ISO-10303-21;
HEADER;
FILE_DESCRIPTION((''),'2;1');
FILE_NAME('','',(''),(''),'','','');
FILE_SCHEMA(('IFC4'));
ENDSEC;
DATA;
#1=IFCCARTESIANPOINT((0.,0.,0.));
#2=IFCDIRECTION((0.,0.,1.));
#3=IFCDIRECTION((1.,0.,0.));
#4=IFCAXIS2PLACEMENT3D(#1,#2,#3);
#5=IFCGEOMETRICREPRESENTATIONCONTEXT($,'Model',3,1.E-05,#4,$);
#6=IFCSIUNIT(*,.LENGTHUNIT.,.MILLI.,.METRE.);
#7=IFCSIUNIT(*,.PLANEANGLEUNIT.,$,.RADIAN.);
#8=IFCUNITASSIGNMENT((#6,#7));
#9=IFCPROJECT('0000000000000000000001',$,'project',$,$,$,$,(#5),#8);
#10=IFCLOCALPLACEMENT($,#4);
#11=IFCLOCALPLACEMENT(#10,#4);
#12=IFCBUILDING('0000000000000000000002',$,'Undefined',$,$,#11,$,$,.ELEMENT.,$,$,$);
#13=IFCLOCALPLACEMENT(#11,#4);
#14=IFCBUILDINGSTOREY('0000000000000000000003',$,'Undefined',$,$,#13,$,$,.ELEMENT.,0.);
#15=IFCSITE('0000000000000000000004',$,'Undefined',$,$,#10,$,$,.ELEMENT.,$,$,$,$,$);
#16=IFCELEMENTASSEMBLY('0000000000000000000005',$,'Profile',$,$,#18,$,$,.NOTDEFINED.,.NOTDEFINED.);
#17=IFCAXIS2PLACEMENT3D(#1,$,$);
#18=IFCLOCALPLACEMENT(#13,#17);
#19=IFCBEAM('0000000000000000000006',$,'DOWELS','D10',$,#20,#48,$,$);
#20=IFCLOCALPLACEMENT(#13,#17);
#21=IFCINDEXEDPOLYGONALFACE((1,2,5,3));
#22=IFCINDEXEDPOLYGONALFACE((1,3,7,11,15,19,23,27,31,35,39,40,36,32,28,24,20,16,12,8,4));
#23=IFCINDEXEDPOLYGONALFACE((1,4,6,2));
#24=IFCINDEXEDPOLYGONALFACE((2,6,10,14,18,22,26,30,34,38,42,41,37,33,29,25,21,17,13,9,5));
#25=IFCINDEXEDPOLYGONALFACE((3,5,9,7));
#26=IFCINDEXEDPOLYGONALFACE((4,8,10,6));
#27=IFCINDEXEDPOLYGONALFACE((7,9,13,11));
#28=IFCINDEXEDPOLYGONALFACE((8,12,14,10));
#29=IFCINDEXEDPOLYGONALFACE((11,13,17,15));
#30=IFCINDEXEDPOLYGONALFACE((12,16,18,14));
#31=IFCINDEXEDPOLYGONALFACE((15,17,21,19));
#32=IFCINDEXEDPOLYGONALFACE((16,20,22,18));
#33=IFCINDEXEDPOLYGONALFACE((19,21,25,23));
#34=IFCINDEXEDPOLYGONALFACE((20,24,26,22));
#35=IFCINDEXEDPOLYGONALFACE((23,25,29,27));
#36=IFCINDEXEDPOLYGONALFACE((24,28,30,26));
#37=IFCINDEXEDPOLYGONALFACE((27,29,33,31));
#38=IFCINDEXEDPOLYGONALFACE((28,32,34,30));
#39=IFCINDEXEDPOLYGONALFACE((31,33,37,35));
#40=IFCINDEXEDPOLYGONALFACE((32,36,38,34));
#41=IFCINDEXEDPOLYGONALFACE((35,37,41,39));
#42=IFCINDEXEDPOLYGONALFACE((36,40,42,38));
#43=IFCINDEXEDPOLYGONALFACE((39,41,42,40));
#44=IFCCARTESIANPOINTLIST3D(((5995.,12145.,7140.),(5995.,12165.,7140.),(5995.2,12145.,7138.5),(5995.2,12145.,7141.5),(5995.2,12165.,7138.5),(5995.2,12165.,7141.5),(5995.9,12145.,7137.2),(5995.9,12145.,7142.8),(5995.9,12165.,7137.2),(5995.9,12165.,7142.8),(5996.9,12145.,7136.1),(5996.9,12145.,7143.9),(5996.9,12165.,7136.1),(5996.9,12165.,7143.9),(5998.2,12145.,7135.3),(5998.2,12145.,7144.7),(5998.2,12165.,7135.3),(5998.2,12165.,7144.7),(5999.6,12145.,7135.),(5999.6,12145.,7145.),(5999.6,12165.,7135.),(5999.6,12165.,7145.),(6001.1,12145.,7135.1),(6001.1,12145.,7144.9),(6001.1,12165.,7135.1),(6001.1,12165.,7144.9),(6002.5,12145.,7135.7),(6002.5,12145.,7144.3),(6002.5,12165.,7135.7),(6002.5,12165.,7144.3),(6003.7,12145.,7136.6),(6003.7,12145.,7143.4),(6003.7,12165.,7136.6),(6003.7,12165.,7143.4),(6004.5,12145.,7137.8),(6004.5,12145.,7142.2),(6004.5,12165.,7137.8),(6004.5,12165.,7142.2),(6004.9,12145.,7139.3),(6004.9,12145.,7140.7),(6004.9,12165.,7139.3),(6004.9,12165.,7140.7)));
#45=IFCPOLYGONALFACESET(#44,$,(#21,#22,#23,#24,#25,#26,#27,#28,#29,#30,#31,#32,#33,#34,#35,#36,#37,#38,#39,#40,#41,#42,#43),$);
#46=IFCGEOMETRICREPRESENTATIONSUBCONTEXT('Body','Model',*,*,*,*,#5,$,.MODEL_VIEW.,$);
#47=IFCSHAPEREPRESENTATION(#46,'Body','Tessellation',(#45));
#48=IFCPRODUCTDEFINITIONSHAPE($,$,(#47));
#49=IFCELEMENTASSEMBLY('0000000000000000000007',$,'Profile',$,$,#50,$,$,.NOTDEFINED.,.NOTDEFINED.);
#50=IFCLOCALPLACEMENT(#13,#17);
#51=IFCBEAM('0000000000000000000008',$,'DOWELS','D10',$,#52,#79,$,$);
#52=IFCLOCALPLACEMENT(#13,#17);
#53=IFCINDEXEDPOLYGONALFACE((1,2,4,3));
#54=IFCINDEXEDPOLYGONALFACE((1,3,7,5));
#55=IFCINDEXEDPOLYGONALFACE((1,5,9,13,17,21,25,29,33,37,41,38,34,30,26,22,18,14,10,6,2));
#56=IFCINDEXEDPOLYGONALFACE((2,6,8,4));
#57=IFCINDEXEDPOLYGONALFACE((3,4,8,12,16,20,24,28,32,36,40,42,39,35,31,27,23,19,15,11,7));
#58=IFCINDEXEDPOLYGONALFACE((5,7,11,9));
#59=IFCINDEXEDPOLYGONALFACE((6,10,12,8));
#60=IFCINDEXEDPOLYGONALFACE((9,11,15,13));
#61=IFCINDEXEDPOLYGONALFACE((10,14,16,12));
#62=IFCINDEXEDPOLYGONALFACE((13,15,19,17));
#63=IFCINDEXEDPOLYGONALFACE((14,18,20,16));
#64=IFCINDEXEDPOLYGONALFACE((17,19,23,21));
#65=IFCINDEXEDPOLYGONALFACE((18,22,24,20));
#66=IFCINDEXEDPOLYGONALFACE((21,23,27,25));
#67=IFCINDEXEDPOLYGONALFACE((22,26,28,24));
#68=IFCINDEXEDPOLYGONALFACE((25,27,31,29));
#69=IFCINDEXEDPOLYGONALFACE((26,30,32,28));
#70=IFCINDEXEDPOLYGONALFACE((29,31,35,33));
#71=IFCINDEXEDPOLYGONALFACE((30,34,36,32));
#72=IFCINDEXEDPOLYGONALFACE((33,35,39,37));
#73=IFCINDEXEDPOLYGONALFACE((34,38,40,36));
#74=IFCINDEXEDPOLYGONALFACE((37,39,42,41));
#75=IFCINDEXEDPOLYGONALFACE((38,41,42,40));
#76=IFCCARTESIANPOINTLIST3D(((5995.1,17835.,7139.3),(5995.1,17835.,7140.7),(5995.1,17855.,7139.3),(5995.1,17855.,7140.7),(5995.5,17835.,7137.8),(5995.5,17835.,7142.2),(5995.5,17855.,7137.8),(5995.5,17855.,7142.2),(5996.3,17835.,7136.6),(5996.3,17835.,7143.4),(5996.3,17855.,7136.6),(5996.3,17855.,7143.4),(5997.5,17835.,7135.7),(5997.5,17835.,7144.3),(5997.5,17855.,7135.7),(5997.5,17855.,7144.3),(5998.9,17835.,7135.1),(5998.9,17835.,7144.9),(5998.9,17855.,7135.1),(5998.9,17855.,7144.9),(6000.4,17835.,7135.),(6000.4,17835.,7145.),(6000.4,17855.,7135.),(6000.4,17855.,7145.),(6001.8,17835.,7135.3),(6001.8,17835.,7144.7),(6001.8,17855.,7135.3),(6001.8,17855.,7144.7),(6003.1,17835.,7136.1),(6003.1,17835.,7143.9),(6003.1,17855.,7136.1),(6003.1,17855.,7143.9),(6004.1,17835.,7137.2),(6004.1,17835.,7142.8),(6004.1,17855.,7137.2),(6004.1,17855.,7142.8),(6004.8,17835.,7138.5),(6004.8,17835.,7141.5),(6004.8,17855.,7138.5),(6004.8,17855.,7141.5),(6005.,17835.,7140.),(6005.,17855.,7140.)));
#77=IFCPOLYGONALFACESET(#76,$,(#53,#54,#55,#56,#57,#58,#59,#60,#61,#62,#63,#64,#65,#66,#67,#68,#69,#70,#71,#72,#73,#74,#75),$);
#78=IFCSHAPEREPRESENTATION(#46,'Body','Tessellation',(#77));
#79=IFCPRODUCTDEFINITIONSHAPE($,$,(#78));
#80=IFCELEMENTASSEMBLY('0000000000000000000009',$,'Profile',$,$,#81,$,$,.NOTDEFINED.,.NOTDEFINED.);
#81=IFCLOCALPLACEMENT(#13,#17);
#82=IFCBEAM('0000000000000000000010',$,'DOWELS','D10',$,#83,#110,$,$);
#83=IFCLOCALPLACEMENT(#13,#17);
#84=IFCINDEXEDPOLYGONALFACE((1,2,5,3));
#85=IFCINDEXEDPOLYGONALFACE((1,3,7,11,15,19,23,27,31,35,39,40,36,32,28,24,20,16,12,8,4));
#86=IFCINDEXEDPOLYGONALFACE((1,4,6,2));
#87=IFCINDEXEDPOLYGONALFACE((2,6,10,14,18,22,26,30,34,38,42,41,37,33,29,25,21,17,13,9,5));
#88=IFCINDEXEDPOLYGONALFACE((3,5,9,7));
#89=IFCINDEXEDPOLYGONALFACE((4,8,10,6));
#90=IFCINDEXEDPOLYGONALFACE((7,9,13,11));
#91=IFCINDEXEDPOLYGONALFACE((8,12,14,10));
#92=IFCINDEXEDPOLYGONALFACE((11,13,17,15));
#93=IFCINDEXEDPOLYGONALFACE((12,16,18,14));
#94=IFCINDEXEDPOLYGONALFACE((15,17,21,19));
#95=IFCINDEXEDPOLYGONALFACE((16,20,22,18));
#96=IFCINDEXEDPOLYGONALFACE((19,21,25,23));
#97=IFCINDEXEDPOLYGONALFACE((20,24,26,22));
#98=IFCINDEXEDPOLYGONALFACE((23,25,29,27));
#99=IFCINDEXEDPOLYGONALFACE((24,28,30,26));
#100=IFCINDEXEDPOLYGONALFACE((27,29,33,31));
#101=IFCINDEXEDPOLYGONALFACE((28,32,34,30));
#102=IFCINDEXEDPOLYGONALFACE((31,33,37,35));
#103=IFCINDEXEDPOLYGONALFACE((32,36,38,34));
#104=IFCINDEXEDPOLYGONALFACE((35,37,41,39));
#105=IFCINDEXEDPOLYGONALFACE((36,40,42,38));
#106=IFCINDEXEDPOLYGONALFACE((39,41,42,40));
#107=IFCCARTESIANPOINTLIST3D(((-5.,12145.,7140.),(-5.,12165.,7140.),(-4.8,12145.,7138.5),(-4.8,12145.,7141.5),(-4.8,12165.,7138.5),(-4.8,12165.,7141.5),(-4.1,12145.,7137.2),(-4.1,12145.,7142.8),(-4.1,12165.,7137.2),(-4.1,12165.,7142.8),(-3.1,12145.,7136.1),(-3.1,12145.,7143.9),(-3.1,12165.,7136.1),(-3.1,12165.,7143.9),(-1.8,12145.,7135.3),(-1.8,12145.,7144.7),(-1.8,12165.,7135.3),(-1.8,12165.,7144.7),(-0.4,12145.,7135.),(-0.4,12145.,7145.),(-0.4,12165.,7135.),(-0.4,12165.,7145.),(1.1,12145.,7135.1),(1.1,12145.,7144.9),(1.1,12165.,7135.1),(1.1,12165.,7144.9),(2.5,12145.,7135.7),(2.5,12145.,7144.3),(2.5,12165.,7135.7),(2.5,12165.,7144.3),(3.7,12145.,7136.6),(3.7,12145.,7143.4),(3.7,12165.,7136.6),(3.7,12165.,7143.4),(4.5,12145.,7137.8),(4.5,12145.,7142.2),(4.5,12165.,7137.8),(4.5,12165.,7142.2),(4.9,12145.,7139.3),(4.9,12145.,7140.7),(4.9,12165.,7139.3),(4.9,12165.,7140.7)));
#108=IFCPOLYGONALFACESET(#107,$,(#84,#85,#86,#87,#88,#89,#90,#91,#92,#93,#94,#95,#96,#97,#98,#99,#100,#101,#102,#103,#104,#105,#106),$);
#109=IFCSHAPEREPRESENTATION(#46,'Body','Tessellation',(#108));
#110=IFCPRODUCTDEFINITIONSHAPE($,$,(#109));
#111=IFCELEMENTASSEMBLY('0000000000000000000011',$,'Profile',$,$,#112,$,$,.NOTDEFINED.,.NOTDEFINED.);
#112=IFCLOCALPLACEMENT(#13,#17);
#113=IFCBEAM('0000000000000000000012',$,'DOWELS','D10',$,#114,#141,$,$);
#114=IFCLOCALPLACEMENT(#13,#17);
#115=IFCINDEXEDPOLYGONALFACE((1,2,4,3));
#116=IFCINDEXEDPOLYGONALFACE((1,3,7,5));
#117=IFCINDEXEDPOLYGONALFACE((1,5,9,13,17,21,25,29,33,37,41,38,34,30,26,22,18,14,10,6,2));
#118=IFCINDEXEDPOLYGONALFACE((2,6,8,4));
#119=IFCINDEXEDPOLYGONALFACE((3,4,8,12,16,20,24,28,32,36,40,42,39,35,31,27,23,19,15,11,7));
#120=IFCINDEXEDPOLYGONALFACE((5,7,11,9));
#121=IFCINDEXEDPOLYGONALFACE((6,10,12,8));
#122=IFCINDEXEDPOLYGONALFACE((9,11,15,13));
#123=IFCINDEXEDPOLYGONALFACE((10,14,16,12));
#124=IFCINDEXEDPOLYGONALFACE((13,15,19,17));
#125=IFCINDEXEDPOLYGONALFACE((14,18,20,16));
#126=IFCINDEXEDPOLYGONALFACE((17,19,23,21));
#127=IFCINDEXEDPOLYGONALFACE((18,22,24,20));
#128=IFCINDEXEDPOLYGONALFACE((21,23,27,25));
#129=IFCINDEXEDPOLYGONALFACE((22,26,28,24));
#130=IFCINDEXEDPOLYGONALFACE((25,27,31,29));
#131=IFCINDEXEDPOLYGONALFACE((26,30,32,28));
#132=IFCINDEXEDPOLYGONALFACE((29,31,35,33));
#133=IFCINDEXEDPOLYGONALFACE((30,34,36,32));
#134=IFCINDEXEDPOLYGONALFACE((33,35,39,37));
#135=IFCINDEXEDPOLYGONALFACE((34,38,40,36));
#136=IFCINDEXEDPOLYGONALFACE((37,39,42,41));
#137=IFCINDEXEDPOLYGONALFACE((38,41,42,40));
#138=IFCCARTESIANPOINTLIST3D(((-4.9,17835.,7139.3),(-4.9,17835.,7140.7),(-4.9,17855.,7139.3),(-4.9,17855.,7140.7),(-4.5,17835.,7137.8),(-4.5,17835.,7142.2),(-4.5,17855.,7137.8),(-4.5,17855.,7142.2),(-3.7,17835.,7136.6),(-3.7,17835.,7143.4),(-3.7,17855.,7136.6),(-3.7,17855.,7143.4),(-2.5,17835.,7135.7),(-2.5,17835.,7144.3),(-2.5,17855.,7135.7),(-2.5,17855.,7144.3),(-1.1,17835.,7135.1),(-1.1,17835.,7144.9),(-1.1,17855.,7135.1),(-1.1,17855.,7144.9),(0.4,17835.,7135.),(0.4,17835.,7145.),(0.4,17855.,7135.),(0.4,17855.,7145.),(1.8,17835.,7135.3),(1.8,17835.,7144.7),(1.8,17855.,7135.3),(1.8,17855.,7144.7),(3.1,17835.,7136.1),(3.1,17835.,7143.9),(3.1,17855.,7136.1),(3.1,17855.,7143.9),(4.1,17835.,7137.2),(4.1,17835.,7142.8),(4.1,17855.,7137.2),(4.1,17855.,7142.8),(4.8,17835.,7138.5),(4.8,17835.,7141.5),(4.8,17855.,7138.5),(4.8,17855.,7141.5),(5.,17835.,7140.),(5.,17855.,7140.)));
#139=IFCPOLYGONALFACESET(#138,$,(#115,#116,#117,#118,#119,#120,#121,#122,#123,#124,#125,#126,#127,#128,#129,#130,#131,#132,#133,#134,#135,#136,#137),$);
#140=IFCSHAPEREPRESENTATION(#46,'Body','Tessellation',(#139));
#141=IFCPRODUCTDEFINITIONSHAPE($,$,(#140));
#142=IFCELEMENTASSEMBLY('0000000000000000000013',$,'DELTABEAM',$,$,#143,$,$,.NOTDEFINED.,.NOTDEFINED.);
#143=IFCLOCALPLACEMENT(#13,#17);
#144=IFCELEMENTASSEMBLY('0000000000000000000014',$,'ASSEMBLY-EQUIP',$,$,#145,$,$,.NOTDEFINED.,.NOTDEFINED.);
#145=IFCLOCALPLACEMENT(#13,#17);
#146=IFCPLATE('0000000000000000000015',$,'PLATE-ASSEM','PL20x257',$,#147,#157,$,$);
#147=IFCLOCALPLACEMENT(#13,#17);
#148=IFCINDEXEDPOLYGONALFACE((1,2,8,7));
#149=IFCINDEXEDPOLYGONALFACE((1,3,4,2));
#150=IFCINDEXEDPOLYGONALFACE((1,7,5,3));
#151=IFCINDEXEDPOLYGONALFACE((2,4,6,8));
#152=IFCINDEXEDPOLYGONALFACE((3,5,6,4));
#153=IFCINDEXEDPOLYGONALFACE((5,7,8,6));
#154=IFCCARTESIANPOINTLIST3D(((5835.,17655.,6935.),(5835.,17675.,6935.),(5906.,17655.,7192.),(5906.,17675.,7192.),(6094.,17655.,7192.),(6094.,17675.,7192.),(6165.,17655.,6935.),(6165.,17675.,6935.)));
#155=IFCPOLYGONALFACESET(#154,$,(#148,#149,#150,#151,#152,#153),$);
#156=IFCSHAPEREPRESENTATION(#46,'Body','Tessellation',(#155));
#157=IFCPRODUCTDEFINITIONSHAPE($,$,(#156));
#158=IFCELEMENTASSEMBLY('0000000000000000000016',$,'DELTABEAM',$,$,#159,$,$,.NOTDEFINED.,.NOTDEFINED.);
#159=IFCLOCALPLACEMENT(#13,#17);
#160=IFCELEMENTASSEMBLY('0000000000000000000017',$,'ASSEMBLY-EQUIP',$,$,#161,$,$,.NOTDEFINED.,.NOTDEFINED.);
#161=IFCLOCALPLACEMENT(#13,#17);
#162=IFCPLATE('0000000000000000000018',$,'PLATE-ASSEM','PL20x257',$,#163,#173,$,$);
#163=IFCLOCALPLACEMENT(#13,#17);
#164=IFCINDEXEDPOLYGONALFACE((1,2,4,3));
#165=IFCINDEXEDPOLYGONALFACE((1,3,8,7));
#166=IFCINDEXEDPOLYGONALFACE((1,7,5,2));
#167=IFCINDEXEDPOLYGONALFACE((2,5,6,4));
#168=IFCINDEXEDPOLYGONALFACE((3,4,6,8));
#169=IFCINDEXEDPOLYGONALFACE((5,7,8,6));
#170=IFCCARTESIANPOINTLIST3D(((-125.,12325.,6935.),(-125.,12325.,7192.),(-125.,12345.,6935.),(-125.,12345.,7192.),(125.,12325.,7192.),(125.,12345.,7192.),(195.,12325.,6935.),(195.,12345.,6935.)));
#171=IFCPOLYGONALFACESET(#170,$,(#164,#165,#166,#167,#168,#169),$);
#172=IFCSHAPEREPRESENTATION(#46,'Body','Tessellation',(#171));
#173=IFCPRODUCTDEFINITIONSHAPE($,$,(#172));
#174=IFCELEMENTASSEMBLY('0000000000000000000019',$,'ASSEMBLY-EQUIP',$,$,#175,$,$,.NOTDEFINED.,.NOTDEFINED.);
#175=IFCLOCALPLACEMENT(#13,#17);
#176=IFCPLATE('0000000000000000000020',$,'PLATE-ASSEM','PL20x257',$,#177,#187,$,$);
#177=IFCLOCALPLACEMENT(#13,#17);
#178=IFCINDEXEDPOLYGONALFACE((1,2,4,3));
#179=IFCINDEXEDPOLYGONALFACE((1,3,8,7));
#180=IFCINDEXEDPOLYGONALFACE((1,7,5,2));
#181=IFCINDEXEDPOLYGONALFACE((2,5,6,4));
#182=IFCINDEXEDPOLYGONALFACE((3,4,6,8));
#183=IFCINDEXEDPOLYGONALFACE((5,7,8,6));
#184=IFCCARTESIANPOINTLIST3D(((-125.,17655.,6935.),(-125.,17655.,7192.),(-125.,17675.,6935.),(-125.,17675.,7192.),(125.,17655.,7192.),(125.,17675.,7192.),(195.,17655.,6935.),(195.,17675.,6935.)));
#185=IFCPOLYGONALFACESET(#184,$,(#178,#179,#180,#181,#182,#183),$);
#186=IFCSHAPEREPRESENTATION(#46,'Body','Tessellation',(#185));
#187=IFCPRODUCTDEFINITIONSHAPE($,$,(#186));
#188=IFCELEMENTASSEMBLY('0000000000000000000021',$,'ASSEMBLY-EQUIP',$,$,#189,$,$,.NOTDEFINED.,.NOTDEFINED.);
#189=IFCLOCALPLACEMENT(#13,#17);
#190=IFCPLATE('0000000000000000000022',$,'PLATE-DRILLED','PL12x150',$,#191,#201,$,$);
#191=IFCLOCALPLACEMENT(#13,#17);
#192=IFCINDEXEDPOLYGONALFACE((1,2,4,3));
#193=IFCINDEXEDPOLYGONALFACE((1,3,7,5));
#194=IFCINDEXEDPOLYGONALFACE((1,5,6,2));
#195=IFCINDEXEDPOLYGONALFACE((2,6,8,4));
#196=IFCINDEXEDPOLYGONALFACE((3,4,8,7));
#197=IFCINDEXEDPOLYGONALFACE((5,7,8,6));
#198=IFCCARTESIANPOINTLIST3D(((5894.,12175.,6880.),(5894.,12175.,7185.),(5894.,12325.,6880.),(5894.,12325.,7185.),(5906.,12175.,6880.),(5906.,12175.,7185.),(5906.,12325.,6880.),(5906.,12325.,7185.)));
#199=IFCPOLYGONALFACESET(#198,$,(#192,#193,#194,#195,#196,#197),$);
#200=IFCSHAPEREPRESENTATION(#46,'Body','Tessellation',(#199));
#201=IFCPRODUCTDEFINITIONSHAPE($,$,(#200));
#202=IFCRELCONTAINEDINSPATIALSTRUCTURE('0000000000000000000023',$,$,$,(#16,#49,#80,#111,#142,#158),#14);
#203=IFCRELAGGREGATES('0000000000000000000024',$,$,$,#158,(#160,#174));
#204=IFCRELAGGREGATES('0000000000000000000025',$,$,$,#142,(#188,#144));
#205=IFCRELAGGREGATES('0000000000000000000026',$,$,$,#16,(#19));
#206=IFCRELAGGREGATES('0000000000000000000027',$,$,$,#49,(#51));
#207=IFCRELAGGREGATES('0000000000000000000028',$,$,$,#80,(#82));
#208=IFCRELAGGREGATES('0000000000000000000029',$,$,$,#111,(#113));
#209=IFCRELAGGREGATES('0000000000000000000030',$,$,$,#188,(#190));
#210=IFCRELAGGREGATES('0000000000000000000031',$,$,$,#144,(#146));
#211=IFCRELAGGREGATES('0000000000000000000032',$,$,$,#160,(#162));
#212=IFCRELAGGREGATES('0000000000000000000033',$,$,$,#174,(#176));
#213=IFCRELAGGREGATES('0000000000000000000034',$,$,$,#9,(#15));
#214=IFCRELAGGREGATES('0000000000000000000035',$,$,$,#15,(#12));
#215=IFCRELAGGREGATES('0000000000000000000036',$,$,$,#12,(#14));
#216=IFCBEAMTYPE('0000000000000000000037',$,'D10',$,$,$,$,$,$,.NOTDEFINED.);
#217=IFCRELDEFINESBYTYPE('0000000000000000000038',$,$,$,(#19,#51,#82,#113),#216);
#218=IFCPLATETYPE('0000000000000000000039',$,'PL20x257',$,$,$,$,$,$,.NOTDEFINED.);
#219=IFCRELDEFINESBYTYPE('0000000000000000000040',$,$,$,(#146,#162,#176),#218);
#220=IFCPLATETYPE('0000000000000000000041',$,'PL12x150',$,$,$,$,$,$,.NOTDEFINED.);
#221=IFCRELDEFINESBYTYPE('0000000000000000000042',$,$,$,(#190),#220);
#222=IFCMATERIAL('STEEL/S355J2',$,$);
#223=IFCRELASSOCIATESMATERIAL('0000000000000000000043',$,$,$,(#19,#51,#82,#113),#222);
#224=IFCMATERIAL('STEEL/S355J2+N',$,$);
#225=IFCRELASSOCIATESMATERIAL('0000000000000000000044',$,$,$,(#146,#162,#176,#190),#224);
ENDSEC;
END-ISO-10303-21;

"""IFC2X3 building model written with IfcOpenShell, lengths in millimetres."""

from ifc_helpers import new_model, si_unit, frame, origin_with_axes, origin_2d_with_axis, place, context, subcontext, project, spatial, polyline, circle, outline, extrude, material, type_object, element, aggregate, save


model = new_model("IFC2X3")

# Units and contexts
model_context = context("Model", 3, precision=1e-05, world=origin_with_axes())
body_context = subcontext(model_context, "Body", "Model", "MODEL_VIEW")
ifc_project = project(units=[si_unit("LENGTHUNIT", "METRE", prefix="MILLI"), si_unit("PLANEANGLEUNIT", "RADIAN")], contexts=[model_context])

# Site, building, storey
site_placement = place(None, origin_with_axes())
site = spatial("IfcSite", under=ifc_project, at=site_placement, Name="Undefined", CompositionType="ELEMENT")
building_placement = place(site_placement, origin_with_axes())
building = spatial("IfcBuilding", under=site, at=building_placement, Name="Undefined", CompositionType="ELEMENT")
storey_placement = place(building_placement, origin_with_axes())
storey = spatial("IfcBuildingStorey", under=building, at=storey_placement, Name="Undefined", CompositionType="ELEMENT", Elevation=0.0)

# Element assemblies, beams
assembly_1_placement = place(storey_placement, origin_with_axes())
assembly_1 = element("IfcElementAssembly", 1, at=assembly_1_placement, inside=storey, Name="Profile", AssemblyPlace="NOTDEFINED", PredefinedType="NOTDEFINED")
ifc_material_1 = material(Name="STEEL/S355J2")
beam_type_1 = type_object("IfcBeamType", Name="D10", PredefinedType="NOTDEFINED")
beam_1_placement = place(assembly_1_placement, frame((6000.0, 12165.0, 7140.0), z_axis=(0.0, 0.0, 1.0), x_axis=(0.0, -1.0, 0.0)))
beam_1 = element("IfcBeam", 2, at=beam_1_placement, type_object=beam_type_1, material=ifc_material_1, Name="DOWELS", Description="D10", context=body_context, shape_type="SweptSolid", body=[
    extrude(circle(Radius=5.0, at=origin_2d_with_axis()), frame((20.0, 0.0, 0.0), z_axis=(-1.0, 0.0, 0.0), x_axis=(0.0, -1.0, 0.0)), (0.0, 0.0, 1.0), 20.0),
])
assembly_2_placement = place(storey_placement, origin_with_axes())
assembly_2 = element("IfcElementAssembly", 3, at=assembly_2_placement, inside=storey, Name="Profile", AssemblyPlace="NOTDEFINED", PredefinedType="NOTDEFINED")
beam_2_placement = place(assembly_2_placement, frame((6000.0, 17835.0, 7140.0), z_axis=(0.0, 0.0, 1.0), x_axis=(0.0, 1.0, 0.0)))
beam_2 = element("IfcBeam", 4, at=beam_2_placement, type_object=beam_type_1, material=ifc_material_1, Name="DOWELS", Description="D10", context=body_context, shape_type="SweptSolid", body=[
    extrude(circle(Radius=5.0, at=origin_2d_with_axis()), frame((20.0, 0.0, 0.0), z_axis=(-1.0, 0.0, 0.0), x_axis=(0.0, -1.0, 0.0)), (0.0, 0.0, 1.0), 20.0),
])
assembly_3_placement = place(storey_placement, origin_with_axes())
assembly_3 = element("IfcElementAssembly", 5, at=assembly_3_placement, inside=storey, Name="Profile", AssemblyPlace="NOTDEFINED", PredefinedType="NOTDEFINED")
beam_3_placement = place(assembly_3_placement, frame((0.0, 12165.0, 7140.0), z_axis=(0.0, 0.0, 1.0), x_axis=(0.0, -1.0, 0.0)))
beam_3 = element("IfcBeam", 6, at=beam_3_placement, type_object=beam_type_1, material=ifc_material_1, Name="DOWELS", Description="D10", context=body_context, shape_type="SweptSolid", body=[
    extrude(circle(Radius=5.0, at=origin_2d_with_axis()), frame((20.0, 0.0, 0.0), z_axis=(-1.0, 0.0, 0.0), x_axis=(0.0, -1.0, 0.0)), (0.0, 0.0, 1.0), 20.0),
])
assembly_4_placement = place(storey_placement, origin_with_axes())
assembly_4 = element("IfcElementAssembly", 7, at=assembly_4_placement, inside=storey, Name="Profile", AssemblyPlace="NOTDEFINED", PredefinedType="NOTDEFINED")
beam_4_placement = place(assembly_4_placement, frame((0.0, 17835.0, 7140.0), z_axis=(0.0, 0.0, 1.0), x_axis=(0.0, 1.0, 0.0)))
beam_4 = element("IfcBeam", 8, at=beam_4_placement, type_object=beam_type_1, material=ifc_material_1, Name="DOWELS", Description="D10", context=body_context, shape_type="SweptSolid", body=[
    extrude(circle(Radius=5.0, at=origin_2d_with_axis()), frame((20.0, 0.0, 0.0), z_axis=(-1.0, 0.0, 0.0), x_axis=(0.0, -1.0, 0.0)), (0.0, 0.0, 1.0), 20.0),
])

# Element assemblies, plate
assembly_5_placement = place(storey_placement, origin_with_axes())
assembly_5 = element("IfcElementAssembly", 9, at=assembly_5_placement, inside=storey, Name="DELTABEAM", AssemblyPlace="NOTDEFINED", PredefinedType="NOTDEFINED")
assembly_6_placement = place(assembly_5_placement, origin_with_axes())
assembly_6 = element("IfcElementAssembly", 10, at=assembly_6_placement, Name="ASSEMBLY-EQUIP", AssemblyPlace="NOTDEFINED", PredefinedType="NOTDEFINED")
ifc_material_2 = material(Name="STEEL/S355J2+N")
plate_type_1 = type_object("IfcPlateType", Name="PL20x257", PredefinedType="NOTDEFINED")
plate_1_placement = place(assembly_6_placement, frame((5835.0, 17665.0, 6935.0), z_axis=(0.0, -1.0, 0.0), x_axis=(1.0, 0.0, 0.0)))
plate_1 = element("IfcPlate", 11, at=plate_1_placement, type_object=plate_type_1, material=ifc_material_2, Name="PLATE-ASSEM", Description="PL20x257", context=body_context, shape_type="SweptSolid", body=[
    extrude(outline(polyline([(0.0, 0.0), (330.0, 0.0), (259.0, 257.0), (71.0, 257.0), (0.0, 0.0)])), frame((0.0, 0.0, -10.0), z_axis=(0.0, 0.0, 1.0), x_axis=(1.0, 0.0, 0.0)), (0.0, 0.0, 1.0), 20.0),
])

# Element assemblies, plates
assembly_7_placement = place(storey_placement, origin_with_axes())
assembly_7 = element("IfcElementAssembly", 12, at=assembly_7_placement, inside=storey, Name="DELTABEAM", AssemblyPlace="NOTDEFINED", PredefinedType="NOTDEFINED")
assembly_8_placement = place(assembly_7_placement, origin_with_axes())
assembly_8 = element("IfcElementAssembly", 13, at=assembly_8_placement, Name="ASSEMBLY-EQUIP", AssemblyPlace="NOTDEFINED", PredefinedType="NOTDEFINED")
plate_2_placement = place(assembly_8_placement, frame((195.0, 12335.0, 6935.0), z_axis=(0.0, 1.0, 0.0), x_axis=(-1.0, 0.0, 0.0)))
plate_2 = element("IfcPlate", 14, at=plate_2_placement, type_object=plate_type_1, material=ifc_material_2, Name="PLATE-ASSEM", Description="PL20x257", context=body_context, shape_type="SweptSolid", body=[
    extrude(outline(polyline([(0.0, 0.0), (320.0, 0.0), (320.0, 257.0), (70.0, 257.0), (0.0, 0.0)])), frame((0.0, 0.0, -10.0), z_axis=(0.0, 0.0, 1.0), x_axis=(1.0, 0.0, 0.0)), (0.0, 0.0, 1.0), 20.0),
])
assembly_9_placement = place(assembly_7_placement, origin_with_axes())
assembly_9 = element("IfcElementAssembly", 15, at=assembly_9_placement, Name="ASSEMBLY-EQUIP", AssemblyPlace="NOTDEFINED", PredefinedType="NOTDEFINED")
aggregate(assembly_7, [assembly_8, assembly_9])
plate_3_placement = place(assembly_9_placement, frame((-125.0, 17665.0, 6935.0), z_axis=(0.0, -1.0, 0.0), x_axis=(1.0, 0.0, 0.0)))
plate_3 = element("IfcPlate", 16, at=plate_3_placement, type_object=plate_type_1, material=ifc_material_2, Name="PLATE-ASSEM", Description="PL20x257", context=body_context, shape_type="SweptSolid", body=[
    extrude(outline(polyline([(0.0, 0.0), (320.0, 0.0), (250.0, 257.0), (0.0, 257.0), (0.0, 0.0)])), frame((0.0, 0.0, -10.0), z_axis=(0.0, 0.0, 1.0), x_axis=(1.0, 0.0, 0.0)), (0.0, 0.0, 1.0), 20.0),
])

# Element assembly
assembly_10_placement = place(assembly_5_placement, origin_with_axes())
assembly_10 = element("IfcElementAssembly", 17, at=assembly_10_placement, Name="ASSEMBLY-EQUIP", AssemblyPlace="NOTDEFINED", PredefinedType="NOTDEFINED")
aggregate(assembly_5, [assembly_10, assembly_6])

# Plate
plate_type_2 = type_object("IfcPlateType", Name="PL12x150", PredefinedType="NOTDEFINED")
plate_4_placement = place(assembly_10_placement, frame((5900.0, 12325.0, 7185.0), z_axis=(1.0, 0.0, 0.0), x_axis=(0.0, -1.0, 0.0)))
plate_4 = element("IfcPlate", 18, at=plate_4_placement, type_object=plate_type_2, material=ifc_material_2, Name="PLATE-DRILLED", Description="PL12x150", context=body_context, shape_type="SweptSolid", body=[
    extrude(outline(polyline([(0.0, 0.0), (150.0, 0.0), (150.0, 0.0), (150.0, 305.0), (150.0, 305.0), (0.0, 305.0), (0.0, 305.0), (0.0, 0.0)])), frame((0.0, 0.0, -6.0), z_axis=(0.0, 0.0, 1.0), x_axis=(1.0, 0.0, 0.0)), (0.0, 0.0, 1.0), 12.0),
])
aggregate(assembly_1, [beam_1])
aggregate(assembly_2, [beam_2])
aggregate(assembly_3, [beam_3])
aggregate(assembly_4, [beam_4])

aggregate(assembly_10, [plate_4])
aggregate(assembly_6, [plate_1])
aggregate(assembly_8, [plate_2])
aggregate(assembly_9, [plate_3])

save(model, "model.ifc")
